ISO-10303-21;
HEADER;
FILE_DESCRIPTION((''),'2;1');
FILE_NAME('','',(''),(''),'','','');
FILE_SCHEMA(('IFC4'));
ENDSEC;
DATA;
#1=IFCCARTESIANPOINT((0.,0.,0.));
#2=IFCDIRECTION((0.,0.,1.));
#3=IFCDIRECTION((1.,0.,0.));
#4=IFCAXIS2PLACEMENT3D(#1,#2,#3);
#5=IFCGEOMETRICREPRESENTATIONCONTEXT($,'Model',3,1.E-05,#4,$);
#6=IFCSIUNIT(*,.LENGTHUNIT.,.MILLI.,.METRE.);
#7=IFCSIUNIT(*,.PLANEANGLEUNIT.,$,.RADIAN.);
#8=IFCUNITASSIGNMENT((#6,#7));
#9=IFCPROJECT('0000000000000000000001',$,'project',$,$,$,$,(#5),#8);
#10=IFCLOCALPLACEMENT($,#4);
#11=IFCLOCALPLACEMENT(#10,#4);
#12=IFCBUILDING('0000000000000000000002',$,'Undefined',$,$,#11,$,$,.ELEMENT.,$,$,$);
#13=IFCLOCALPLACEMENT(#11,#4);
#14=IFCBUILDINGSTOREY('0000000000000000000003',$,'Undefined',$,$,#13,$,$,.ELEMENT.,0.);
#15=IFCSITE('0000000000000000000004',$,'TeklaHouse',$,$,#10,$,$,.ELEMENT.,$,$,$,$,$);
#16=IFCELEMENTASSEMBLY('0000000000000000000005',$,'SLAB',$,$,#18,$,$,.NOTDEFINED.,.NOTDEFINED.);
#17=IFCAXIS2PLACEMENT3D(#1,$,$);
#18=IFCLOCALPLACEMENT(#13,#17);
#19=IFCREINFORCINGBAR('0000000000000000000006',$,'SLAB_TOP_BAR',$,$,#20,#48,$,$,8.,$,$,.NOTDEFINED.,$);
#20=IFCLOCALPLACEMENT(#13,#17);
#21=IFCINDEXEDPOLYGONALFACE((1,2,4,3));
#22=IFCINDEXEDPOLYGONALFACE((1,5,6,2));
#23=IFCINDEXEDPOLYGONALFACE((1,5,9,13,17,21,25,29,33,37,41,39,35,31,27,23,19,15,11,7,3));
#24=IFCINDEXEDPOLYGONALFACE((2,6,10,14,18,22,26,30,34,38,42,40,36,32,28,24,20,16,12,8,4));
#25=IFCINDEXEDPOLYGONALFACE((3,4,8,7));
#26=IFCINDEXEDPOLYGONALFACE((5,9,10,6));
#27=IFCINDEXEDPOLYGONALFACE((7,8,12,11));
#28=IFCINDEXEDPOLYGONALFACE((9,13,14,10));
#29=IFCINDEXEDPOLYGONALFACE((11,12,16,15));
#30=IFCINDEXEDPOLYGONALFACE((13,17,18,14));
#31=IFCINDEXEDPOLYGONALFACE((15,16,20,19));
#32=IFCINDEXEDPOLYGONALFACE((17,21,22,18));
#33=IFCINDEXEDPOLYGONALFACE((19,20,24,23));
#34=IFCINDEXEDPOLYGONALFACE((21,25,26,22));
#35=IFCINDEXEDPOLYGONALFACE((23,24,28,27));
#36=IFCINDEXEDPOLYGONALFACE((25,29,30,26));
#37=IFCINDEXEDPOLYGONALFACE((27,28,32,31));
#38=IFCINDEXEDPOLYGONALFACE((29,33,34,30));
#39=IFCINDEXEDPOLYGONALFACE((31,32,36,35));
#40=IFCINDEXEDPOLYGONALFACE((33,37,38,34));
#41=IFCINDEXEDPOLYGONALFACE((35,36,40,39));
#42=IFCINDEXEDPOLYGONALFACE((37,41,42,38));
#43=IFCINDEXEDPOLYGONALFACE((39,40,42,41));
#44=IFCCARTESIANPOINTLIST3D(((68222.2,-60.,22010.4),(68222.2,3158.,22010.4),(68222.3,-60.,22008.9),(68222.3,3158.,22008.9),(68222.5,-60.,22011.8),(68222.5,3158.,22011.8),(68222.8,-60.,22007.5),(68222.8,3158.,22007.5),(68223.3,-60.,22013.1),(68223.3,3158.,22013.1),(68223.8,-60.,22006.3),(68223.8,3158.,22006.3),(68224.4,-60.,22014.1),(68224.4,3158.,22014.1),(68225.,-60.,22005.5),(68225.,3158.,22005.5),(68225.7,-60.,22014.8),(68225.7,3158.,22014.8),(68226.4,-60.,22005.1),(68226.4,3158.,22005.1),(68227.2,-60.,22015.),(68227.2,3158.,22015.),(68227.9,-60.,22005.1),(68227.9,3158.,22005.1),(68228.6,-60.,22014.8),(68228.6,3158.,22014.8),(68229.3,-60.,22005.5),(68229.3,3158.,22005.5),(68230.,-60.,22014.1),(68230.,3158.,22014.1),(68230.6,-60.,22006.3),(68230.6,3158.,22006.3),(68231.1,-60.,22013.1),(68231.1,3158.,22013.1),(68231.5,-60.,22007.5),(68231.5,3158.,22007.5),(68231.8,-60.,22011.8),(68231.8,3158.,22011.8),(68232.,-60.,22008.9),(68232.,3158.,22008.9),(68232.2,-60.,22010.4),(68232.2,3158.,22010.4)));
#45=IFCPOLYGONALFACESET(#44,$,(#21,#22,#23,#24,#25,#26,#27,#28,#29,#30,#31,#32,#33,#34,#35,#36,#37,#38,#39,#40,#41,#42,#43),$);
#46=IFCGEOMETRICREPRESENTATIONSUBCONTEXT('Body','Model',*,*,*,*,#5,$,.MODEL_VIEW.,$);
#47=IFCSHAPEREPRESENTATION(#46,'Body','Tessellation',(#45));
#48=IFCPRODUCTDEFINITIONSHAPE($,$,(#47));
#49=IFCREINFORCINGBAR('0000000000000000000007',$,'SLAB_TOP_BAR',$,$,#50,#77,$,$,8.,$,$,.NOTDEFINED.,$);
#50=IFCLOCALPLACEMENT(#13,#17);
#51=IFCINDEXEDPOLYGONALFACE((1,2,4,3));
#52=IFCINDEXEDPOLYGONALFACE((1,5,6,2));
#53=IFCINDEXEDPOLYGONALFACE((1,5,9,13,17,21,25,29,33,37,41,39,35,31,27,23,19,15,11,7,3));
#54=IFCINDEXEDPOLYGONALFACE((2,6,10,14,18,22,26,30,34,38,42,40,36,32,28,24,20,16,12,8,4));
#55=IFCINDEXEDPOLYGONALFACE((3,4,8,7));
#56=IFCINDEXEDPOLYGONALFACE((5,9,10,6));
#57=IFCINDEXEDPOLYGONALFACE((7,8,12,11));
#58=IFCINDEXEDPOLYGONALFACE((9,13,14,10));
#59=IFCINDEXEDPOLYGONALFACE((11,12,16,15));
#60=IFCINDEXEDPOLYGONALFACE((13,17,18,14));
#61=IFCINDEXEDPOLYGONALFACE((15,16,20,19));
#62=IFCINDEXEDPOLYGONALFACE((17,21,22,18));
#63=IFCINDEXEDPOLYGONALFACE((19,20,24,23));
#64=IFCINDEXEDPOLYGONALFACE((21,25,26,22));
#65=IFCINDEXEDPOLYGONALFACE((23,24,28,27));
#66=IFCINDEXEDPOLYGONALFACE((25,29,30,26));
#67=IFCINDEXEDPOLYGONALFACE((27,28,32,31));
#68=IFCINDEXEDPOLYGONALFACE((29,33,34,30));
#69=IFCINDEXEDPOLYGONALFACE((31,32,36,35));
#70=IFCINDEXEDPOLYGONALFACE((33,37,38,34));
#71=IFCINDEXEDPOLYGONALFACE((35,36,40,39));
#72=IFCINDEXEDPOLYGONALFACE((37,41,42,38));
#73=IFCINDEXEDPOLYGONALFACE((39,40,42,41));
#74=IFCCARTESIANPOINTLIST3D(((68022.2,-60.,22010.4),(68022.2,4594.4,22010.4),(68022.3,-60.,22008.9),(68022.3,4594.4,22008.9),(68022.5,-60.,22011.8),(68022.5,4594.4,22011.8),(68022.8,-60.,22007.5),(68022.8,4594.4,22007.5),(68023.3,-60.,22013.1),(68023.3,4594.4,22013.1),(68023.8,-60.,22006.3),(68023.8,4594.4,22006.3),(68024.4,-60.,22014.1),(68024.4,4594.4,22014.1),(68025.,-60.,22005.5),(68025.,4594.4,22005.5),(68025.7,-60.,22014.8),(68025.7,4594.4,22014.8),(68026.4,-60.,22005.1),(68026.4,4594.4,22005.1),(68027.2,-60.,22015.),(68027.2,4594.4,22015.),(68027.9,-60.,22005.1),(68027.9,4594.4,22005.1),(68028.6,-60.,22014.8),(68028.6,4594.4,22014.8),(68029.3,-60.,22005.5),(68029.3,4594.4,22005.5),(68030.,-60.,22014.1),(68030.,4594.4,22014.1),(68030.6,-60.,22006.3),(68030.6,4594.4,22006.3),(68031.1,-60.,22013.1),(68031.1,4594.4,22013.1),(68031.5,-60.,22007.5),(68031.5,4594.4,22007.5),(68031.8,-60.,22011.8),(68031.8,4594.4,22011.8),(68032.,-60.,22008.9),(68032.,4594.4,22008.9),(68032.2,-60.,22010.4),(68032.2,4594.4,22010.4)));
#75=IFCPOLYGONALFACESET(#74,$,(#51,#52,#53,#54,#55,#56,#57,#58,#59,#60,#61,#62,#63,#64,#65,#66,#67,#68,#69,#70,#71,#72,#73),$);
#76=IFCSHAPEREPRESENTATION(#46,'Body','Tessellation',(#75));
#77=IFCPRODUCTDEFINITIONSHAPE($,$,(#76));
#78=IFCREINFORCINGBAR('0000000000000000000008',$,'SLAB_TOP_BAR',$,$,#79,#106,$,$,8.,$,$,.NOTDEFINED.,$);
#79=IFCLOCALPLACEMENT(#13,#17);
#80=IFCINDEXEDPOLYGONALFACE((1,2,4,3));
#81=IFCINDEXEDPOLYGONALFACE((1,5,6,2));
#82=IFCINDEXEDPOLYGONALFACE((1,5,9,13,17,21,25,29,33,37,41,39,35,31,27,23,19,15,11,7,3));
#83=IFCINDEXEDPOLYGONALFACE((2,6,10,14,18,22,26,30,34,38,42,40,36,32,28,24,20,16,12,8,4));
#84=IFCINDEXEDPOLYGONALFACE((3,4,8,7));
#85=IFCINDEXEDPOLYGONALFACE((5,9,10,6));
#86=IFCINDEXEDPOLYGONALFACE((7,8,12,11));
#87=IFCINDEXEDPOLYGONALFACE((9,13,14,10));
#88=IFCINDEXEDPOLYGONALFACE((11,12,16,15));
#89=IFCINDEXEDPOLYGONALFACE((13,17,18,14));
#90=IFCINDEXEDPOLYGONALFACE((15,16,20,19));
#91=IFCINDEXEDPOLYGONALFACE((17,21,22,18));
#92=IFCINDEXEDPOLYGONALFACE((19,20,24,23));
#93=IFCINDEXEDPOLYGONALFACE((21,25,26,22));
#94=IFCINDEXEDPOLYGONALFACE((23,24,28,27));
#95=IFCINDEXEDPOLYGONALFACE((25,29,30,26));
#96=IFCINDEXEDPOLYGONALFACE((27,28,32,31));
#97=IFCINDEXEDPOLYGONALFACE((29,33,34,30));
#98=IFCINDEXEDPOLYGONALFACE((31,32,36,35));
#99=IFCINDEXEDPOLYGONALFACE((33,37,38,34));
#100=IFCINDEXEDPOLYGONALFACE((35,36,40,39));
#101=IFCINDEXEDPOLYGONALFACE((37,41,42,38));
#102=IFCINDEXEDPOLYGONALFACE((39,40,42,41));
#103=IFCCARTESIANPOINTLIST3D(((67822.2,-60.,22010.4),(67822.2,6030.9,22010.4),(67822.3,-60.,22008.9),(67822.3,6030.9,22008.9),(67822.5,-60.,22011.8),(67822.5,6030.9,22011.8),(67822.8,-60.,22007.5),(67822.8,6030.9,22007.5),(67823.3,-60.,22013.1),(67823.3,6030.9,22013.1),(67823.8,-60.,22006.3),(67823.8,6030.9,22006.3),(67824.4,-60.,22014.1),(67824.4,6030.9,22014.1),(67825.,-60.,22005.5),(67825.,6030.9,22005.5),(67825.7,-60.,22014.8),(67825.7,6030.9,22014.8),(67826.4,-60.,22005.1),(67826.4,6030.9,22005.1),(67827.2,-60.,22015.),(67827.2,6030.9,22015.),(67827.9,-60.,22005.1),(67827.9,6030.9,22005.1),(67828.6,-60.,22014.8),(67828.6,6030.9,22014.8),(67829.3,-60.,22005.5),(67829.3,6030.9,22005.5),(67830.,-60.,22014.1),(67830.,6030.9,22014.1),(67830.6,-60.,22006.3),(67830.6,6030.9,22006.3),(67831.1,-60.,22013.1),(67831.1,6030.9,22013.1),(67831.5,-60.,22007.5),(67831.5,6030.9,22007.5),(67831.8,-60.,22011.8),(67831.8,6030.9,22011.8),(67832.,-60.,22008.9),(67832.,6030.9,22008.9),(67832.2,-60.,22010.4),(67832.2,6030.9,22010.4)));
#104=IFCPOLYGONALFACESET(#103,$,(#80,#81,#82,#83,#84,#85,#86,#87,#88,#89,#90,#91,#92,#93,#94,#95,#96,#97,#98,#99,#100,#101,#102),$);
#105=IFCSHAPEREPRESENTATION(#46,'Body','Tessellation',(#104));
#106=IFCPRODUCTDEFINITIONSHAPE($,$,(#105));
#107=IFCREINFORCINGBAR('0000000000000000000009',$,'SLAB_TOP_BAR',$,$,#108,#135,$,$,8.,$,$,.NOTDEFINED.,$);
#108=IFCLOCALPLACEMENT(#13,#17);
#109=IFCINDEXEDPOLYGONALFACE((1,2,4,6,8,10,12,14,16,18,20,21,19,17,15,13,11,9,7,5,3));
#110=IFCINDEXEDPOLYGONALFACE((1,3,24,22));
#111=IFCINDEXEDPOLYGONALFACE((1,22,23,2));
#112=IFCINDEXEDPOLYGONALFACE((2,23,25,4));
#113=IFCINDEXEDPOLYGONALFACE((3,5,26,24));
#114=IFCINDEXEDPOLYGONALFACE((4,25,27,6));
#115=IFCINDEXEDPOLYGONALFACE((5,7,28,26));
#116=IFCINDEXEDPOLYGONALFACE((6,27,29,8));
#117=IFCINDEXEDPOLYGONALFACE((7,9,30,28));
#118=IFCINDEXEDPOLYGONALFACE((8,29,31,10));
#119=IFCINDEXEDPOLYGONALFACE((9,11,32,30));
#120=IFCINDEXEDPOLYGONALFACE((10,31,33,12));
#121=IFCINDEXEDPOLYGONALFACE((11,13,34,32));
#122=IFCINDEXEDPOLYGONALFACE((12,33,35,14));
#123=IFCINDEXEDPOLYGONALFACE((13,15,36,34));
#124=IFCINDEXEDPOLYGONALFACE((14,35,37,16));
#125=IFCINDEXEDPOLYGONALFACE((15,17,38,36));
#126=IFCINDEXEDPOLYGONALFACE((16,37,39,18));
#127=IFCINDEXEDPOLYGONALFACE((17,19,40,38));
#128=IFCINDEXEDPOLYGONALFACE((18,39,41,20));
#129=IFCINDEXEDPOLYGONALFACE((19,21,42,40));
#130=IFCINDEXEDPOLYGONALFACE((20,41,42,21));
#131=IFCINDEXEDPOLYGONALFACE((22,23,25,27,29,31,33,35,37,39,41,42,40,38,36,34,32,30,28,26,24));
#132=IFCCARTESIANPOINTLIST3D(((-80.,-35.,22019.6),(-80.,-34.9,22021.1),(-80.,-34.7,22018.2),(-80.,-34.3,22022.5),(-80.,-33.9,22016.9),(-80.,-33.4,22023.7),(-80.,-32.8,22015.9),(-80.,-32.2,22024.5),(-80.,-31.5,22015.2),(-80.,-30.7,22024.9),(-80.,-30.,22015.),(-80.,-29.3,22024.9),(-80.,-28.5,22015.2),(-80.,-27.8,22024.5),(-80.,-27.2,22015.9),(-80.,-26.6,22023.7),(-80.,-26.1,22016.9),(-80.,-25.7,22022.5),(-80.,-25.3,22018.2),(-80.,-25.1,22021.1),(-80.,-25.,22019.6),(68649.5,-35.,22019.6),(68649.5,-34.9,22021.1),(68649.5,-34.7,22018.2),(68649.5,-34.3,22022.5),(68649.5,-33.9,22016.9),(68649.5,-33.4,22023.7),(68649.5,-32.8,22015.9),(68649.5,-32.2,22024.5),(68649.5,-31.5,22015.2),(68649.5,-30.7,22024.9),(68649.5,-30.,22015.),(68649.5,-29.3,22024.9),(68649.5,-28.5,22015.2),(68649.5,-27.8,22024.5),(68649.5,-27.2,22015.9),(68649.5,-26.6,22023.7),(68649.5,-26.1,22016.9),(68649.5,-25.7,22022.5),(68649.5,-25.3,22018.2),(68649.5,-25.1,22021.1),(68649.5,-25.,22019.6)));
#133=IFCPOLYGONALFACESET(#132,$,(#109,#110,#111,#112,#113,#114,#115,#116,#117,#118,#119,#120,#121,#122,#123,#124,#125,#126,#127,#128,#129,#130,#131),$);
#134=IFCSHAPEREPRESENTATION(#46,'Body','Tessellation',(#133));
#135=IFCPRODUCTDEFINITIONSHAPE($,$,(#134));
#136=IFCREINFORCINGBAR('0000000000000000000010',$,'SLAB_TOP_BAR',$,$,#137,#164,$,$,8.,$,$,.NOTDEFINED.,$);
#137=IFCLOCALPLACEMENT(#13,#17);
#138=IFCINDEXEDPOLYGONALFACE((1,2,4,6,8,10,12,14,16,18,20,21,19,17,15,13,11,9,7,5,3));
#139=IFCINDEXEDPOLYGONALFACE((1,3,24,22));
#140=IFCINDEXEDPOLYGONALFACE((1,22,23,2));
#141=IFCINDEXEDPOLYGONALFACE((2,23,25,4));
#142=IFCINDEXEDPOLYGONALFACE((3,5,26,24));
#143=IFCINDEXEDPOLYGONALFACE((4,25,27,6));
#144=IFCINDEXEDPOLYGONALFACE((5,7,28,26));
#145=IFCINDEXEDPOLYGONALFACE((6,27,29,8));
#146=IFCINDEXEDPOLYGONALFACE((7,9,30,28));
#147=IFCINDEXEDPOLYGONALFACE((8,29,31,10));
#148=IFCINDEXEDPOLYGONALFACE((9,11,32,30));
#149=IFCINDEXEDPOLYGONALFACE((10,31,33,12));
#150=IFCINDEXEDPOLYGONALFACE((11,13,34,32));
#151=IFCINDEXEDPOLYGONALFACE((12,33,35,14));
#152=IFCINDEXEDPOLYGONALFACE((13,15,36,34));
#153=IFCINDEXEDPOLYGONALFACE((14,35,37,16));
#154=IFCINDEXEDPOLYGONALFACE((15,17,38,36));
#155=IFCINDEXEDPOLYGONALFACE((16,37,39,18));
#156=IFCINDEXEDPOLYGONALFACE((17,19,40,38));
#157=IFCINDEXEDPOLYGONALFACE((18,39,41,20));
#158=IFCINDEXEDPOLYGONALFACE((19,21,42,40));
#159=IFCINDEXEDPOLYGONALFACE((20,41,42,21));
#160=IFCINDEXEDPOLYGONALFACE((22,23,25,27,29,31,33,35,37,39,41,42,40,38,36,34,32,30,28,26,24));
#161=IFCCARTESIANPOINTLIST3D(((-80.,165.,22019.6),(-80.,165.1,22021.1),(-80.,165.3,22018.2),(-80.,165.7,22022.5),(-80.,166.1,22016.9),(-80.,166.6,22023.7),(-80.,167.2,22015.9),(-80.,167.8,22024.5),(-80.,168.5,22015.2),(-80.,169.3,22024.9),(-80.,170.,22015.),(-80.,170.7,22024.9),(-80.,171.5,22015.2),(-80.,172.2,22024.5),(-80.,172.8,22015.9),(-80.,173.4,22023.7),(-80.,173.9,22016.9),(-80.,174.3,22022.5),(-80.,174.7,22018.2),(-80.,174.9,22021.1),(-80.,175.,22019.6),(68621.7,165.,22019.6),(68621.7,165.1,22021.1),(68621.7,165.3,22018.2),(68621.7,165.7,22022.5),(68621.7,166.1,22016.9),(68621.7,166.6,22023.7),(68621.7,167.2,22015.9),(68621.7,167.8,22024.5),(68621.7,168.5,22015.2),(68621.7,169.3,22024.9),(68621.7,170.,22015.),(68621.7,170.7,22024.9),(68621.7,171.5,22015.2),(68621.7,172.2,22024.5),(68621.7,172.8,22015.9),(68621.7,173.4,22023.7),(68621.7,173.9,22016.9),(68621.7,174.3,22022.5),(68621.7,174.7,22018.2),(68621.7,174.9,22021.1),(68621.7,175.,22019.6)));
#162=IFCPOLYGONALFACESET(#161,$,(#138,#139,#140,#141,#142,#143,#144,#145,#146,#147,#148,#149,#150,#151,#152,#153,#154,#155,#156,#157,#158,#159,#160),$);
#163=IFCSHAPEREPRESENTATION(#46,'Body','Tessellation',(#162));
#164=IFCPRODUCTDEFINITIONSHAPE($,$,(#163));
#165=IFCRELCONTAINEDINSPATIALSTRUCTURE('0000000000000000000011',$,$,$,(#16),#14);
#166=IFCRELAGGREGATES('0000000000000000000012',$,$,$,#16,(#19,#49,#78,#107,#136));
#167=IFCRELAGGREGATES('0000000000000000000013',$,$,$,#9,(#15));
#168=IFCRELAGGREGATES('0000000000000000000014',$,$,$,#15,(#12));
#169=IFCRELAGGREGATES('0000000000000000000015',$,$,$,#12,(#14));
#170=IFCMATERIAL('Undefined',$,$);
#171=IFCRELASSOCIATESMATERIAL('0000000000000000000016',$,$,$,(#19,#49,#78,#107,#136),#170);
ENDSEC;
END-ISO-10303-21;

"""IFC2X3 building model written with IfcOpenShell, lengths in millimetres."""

from ifc_helpers import new_model, entity, si_unit, frame, origin_with_axes, place, context, subcontext, project, spatial, source, transform, mapped, material, element, aggregate, save


model = new_model("IFC2X3")

# Units and contexts
model_context = context("Model", 3, precision=1e-05, world=origin_with_axes())
body_context = subcontext(model_context, "Body", "Model", "MODEL_VIEW")
ifc_project = project(units=[si_unit("LENGTHUNIT", "METRE", prefix="MILLI"), si_unit("PLANEANGLEUNIT", "RADIAN")], contexts=[model_context])

# Site, building, storey
site_placement = place(None, origin_with_axes())
site = spatial("IfcSite", under=ifc_project, at=site_placement, Name="TeklaHouse", CompositionType="ELEMENT")
building_placement = place(site_placement, origin_with_axes())
building = spatial("IfcBuilding", under=site, at=building_placement, Name="Undefined", CompositionType="ELEMENT")
storey_placement = place(building_placement, origin_with_axes())
storey = spatial("IfcBuildingStorey", under=building, at=storey_placement, Name="Undefined", CompositionType="ELEMENT", Elevation=0.0)

# Shared definitions
ifc_material_1 = material(Name="Undefined")

# Element assembly, reinforcing bars
assembly_1_placement = place(storey_placement, origin_with_axes())
assembly_1 = element("IfcElementAssembly", 1, at=assembly_1_placement, inside=storey, Name="SLAB", AssemblyPlace="NOTDEFINED", PredefinedType="NOTDEFINED")
shared_shape_1 = source(origin_with_axes(), body_context, "Body", "AdvancedSweptSolid", [
    entity("IfcSweptDiskSolid", entity("IfcTrimmedCurve", entity("IfcLine", entity("IfcCartesianPoint", [0.0, 0.0, 0.0]), entity("IfcVector", entity("IfcDirection", [1.0, 0.0, 0.0]), 1.0)), [entity("IfcParameterValue", 0.0)], [entity("IfcParameterValue", 3217.992044)], True, "PARAMETER"), 5.0, None, 0.0, 3218.0),
])
reinforcing_bar_1_placement = place(assembly_1_placement, frame((68227.2, -60.0, 22010.0), z_axis=(0.0, 0.0, 1.0), x_axis=(0.0, 1.0, 0.0)))
reinforcing_bar_1 = element("IfcReinforcingBar", 2, at=reinforcing_bar_1_placement, material=ifc_material_1, Name="SLAB_TOP_BAR", BarRole="NOTDEFINED", NominalDiameter=8.0, context=body_context, shape_type="MappedRepresentation", body=[
    mapped(shared_shape_1, transform((0.0, 0.0, 0.0))),
])
shared_shape_2 = source(origin_with_axes(), body_context, "Body", "AdvancedSweptSolid", [
    entity("IfcSweptDiskSolid", entity("IfcTrimmedCurve", entity("IfcLine", entity("IfcCartesianPoint", [0.0, 0.0, 0.0]), entity("IfcVector", entity("IfcDirection", [1.0, 0.0, 0.0]), 1.0)), [entity("IfcParameterValue", 0.0)], [entity("IfcParameterValue", 4654.440492)], True, "PARAMETER"), 5.0, None, 0.0, 4654.4),
])
reinforcing_bar_2_placement = place(assembly_1_placement, frame((68027.2, -60.0, 22010.0), z_axis=(0.0, 0.0, 1.0), x_axis=(0.0, 1.0, 0.0)))
reinforcing_bar_2 = element("IfcReinforcingBar", 3, at=reinforcing_bar_2_placement, material=ifc_material_1, Name="SLAB_TOP_BAR", BarRole="NOTDEFINED", NominalDiameter=8.0, context=body_context, shape_type="MappedRepresentation", body=[
    mapped(shared_shape_2, transform((0.0, 0.0, 0.0))),
])
shared_shape_3 = source(origin_with_axes(), body_context, "Body", "AdvancedSweptSolid", [
    entity("IfcSweptDiskSolid", entity("IfcTrimmedCurve", entity("IfcLine", entity("IfcCartesianPoint", [0.0, 0.0, 0.0]), entity("IfcVector", entity("IfcDirection", [1.0, 0.0, 0.0]), 1.0)), [entity("IfcParameterValue", 0.0)], [entity("IfcParameterValue", 6090.888941)], True, "PARAMETER"), 5.0, None, 0.0, 6090.9),
])
reinforcing_bar_3_placement = place(assembly_1_placement, frame((67827.2, -60.0, 22010.0), z_axis=(0.0, 0.0, 1.0), x_axis=(0.0, 1.0, 0.0)))
reinforcing_bar_3 = element("IfcReinforcingBar", 4, at=reinforcing_bar_3_placement, material=ifc_material_1, Name="SLAB_TOP_BAR", BarRole="NOTDEFINED", NominalDiameter=8.0, context=body_context, shape_type="MappedRepresentation", body=[
    mapped(shared_shape_3, transform((0.0, 0.0, 0.0))),
])
shared_shape_4 = source(origin_with_axes(), body_context, "Body", "AdvancedSweptSolid", [
    entity("IfcSweptDiskSolid", entity("IfcTrimmedCurve", entity("IfcLine", entity("IfcCartesianPoint", [0.0, 0.0, 0.0]), entity("IfcVector", entity("IfcDirection", [1.0, 0.0, 0.0]), 1.0)), [entity("IfcParameterValue", 0.0)], [entity("IfcParameterValue", 68729.512707)], True, "PARAMETER"), 5.0, None, 0.0, 68729.5),
])
reinforcing_bar_4_placement = place(assembly_1_placement, frame((68649.5, -30.0, 22020.0), z_axis=(0.0, 0.0, -1.0), x_axis=(-1.0, 0.0, 0.0)))
reinforcing_bar_4 = element("IfcReinforcingBar", 5, at=reinforcing_bar_4_placement, material=ifc_material_1, Name="SLAB_TOP_BAR", BarRole="NOTDEFINED", NominalDiameter=8.0, context=body_context, shape_type="MappedRepresentation", body=[
    mapped(shared_shape_4, transform((0.0, 0.0, 0.0))),
])
shared_shape_5 = source(origin_with_axes(), body_context, "Body", "AdvancedSweptSolid", [
    entity("IfcSweptDiskSolid", entity("IfcTrimmedCurve", entity("IfcLine", entity("IfcCartesianPoint", [0.0, 0.0, 0.0]), entity("IfcVector", entity("IfcDirection", [1.0, 0.0, 0.0]), 1.0)), [entity("IfcParameterValue", 0.0)], [entity("IfcParameterValue", 68701.66625)], True, "PARAMETER"), 5.0, None, 0.0, 68701.7),
])
reinforcing_bar_5_placement = place(assembly_1_placement, frame((68621.7, 170.0, 22020.0), z_axis=(0.0, 0.0, -1.0), x_axis=(-1.0, 0.0, 0.0)))
reinforcing_bar_5 = element("IfcReinforcingBar", 6, at=reinforcing_bar_5_placement, material=ifc_material_1, Name="SLAB_TOP_BAR", BarRole="NOTDEFINED", NominalDiameter=8.0, context=body_context, shape_type="MappedRepresentation", body=[
    mapped(shared_shape_5, transform((0.0, 0.0, 0.0))),
])
aggregate(assembly_1, [reinforcing_bar_1, reinforcing_bar_2, reinforcing_bar_3, reinforcing_bar_4, reinforcing_bar_5])

save(model, "model.ifc")
